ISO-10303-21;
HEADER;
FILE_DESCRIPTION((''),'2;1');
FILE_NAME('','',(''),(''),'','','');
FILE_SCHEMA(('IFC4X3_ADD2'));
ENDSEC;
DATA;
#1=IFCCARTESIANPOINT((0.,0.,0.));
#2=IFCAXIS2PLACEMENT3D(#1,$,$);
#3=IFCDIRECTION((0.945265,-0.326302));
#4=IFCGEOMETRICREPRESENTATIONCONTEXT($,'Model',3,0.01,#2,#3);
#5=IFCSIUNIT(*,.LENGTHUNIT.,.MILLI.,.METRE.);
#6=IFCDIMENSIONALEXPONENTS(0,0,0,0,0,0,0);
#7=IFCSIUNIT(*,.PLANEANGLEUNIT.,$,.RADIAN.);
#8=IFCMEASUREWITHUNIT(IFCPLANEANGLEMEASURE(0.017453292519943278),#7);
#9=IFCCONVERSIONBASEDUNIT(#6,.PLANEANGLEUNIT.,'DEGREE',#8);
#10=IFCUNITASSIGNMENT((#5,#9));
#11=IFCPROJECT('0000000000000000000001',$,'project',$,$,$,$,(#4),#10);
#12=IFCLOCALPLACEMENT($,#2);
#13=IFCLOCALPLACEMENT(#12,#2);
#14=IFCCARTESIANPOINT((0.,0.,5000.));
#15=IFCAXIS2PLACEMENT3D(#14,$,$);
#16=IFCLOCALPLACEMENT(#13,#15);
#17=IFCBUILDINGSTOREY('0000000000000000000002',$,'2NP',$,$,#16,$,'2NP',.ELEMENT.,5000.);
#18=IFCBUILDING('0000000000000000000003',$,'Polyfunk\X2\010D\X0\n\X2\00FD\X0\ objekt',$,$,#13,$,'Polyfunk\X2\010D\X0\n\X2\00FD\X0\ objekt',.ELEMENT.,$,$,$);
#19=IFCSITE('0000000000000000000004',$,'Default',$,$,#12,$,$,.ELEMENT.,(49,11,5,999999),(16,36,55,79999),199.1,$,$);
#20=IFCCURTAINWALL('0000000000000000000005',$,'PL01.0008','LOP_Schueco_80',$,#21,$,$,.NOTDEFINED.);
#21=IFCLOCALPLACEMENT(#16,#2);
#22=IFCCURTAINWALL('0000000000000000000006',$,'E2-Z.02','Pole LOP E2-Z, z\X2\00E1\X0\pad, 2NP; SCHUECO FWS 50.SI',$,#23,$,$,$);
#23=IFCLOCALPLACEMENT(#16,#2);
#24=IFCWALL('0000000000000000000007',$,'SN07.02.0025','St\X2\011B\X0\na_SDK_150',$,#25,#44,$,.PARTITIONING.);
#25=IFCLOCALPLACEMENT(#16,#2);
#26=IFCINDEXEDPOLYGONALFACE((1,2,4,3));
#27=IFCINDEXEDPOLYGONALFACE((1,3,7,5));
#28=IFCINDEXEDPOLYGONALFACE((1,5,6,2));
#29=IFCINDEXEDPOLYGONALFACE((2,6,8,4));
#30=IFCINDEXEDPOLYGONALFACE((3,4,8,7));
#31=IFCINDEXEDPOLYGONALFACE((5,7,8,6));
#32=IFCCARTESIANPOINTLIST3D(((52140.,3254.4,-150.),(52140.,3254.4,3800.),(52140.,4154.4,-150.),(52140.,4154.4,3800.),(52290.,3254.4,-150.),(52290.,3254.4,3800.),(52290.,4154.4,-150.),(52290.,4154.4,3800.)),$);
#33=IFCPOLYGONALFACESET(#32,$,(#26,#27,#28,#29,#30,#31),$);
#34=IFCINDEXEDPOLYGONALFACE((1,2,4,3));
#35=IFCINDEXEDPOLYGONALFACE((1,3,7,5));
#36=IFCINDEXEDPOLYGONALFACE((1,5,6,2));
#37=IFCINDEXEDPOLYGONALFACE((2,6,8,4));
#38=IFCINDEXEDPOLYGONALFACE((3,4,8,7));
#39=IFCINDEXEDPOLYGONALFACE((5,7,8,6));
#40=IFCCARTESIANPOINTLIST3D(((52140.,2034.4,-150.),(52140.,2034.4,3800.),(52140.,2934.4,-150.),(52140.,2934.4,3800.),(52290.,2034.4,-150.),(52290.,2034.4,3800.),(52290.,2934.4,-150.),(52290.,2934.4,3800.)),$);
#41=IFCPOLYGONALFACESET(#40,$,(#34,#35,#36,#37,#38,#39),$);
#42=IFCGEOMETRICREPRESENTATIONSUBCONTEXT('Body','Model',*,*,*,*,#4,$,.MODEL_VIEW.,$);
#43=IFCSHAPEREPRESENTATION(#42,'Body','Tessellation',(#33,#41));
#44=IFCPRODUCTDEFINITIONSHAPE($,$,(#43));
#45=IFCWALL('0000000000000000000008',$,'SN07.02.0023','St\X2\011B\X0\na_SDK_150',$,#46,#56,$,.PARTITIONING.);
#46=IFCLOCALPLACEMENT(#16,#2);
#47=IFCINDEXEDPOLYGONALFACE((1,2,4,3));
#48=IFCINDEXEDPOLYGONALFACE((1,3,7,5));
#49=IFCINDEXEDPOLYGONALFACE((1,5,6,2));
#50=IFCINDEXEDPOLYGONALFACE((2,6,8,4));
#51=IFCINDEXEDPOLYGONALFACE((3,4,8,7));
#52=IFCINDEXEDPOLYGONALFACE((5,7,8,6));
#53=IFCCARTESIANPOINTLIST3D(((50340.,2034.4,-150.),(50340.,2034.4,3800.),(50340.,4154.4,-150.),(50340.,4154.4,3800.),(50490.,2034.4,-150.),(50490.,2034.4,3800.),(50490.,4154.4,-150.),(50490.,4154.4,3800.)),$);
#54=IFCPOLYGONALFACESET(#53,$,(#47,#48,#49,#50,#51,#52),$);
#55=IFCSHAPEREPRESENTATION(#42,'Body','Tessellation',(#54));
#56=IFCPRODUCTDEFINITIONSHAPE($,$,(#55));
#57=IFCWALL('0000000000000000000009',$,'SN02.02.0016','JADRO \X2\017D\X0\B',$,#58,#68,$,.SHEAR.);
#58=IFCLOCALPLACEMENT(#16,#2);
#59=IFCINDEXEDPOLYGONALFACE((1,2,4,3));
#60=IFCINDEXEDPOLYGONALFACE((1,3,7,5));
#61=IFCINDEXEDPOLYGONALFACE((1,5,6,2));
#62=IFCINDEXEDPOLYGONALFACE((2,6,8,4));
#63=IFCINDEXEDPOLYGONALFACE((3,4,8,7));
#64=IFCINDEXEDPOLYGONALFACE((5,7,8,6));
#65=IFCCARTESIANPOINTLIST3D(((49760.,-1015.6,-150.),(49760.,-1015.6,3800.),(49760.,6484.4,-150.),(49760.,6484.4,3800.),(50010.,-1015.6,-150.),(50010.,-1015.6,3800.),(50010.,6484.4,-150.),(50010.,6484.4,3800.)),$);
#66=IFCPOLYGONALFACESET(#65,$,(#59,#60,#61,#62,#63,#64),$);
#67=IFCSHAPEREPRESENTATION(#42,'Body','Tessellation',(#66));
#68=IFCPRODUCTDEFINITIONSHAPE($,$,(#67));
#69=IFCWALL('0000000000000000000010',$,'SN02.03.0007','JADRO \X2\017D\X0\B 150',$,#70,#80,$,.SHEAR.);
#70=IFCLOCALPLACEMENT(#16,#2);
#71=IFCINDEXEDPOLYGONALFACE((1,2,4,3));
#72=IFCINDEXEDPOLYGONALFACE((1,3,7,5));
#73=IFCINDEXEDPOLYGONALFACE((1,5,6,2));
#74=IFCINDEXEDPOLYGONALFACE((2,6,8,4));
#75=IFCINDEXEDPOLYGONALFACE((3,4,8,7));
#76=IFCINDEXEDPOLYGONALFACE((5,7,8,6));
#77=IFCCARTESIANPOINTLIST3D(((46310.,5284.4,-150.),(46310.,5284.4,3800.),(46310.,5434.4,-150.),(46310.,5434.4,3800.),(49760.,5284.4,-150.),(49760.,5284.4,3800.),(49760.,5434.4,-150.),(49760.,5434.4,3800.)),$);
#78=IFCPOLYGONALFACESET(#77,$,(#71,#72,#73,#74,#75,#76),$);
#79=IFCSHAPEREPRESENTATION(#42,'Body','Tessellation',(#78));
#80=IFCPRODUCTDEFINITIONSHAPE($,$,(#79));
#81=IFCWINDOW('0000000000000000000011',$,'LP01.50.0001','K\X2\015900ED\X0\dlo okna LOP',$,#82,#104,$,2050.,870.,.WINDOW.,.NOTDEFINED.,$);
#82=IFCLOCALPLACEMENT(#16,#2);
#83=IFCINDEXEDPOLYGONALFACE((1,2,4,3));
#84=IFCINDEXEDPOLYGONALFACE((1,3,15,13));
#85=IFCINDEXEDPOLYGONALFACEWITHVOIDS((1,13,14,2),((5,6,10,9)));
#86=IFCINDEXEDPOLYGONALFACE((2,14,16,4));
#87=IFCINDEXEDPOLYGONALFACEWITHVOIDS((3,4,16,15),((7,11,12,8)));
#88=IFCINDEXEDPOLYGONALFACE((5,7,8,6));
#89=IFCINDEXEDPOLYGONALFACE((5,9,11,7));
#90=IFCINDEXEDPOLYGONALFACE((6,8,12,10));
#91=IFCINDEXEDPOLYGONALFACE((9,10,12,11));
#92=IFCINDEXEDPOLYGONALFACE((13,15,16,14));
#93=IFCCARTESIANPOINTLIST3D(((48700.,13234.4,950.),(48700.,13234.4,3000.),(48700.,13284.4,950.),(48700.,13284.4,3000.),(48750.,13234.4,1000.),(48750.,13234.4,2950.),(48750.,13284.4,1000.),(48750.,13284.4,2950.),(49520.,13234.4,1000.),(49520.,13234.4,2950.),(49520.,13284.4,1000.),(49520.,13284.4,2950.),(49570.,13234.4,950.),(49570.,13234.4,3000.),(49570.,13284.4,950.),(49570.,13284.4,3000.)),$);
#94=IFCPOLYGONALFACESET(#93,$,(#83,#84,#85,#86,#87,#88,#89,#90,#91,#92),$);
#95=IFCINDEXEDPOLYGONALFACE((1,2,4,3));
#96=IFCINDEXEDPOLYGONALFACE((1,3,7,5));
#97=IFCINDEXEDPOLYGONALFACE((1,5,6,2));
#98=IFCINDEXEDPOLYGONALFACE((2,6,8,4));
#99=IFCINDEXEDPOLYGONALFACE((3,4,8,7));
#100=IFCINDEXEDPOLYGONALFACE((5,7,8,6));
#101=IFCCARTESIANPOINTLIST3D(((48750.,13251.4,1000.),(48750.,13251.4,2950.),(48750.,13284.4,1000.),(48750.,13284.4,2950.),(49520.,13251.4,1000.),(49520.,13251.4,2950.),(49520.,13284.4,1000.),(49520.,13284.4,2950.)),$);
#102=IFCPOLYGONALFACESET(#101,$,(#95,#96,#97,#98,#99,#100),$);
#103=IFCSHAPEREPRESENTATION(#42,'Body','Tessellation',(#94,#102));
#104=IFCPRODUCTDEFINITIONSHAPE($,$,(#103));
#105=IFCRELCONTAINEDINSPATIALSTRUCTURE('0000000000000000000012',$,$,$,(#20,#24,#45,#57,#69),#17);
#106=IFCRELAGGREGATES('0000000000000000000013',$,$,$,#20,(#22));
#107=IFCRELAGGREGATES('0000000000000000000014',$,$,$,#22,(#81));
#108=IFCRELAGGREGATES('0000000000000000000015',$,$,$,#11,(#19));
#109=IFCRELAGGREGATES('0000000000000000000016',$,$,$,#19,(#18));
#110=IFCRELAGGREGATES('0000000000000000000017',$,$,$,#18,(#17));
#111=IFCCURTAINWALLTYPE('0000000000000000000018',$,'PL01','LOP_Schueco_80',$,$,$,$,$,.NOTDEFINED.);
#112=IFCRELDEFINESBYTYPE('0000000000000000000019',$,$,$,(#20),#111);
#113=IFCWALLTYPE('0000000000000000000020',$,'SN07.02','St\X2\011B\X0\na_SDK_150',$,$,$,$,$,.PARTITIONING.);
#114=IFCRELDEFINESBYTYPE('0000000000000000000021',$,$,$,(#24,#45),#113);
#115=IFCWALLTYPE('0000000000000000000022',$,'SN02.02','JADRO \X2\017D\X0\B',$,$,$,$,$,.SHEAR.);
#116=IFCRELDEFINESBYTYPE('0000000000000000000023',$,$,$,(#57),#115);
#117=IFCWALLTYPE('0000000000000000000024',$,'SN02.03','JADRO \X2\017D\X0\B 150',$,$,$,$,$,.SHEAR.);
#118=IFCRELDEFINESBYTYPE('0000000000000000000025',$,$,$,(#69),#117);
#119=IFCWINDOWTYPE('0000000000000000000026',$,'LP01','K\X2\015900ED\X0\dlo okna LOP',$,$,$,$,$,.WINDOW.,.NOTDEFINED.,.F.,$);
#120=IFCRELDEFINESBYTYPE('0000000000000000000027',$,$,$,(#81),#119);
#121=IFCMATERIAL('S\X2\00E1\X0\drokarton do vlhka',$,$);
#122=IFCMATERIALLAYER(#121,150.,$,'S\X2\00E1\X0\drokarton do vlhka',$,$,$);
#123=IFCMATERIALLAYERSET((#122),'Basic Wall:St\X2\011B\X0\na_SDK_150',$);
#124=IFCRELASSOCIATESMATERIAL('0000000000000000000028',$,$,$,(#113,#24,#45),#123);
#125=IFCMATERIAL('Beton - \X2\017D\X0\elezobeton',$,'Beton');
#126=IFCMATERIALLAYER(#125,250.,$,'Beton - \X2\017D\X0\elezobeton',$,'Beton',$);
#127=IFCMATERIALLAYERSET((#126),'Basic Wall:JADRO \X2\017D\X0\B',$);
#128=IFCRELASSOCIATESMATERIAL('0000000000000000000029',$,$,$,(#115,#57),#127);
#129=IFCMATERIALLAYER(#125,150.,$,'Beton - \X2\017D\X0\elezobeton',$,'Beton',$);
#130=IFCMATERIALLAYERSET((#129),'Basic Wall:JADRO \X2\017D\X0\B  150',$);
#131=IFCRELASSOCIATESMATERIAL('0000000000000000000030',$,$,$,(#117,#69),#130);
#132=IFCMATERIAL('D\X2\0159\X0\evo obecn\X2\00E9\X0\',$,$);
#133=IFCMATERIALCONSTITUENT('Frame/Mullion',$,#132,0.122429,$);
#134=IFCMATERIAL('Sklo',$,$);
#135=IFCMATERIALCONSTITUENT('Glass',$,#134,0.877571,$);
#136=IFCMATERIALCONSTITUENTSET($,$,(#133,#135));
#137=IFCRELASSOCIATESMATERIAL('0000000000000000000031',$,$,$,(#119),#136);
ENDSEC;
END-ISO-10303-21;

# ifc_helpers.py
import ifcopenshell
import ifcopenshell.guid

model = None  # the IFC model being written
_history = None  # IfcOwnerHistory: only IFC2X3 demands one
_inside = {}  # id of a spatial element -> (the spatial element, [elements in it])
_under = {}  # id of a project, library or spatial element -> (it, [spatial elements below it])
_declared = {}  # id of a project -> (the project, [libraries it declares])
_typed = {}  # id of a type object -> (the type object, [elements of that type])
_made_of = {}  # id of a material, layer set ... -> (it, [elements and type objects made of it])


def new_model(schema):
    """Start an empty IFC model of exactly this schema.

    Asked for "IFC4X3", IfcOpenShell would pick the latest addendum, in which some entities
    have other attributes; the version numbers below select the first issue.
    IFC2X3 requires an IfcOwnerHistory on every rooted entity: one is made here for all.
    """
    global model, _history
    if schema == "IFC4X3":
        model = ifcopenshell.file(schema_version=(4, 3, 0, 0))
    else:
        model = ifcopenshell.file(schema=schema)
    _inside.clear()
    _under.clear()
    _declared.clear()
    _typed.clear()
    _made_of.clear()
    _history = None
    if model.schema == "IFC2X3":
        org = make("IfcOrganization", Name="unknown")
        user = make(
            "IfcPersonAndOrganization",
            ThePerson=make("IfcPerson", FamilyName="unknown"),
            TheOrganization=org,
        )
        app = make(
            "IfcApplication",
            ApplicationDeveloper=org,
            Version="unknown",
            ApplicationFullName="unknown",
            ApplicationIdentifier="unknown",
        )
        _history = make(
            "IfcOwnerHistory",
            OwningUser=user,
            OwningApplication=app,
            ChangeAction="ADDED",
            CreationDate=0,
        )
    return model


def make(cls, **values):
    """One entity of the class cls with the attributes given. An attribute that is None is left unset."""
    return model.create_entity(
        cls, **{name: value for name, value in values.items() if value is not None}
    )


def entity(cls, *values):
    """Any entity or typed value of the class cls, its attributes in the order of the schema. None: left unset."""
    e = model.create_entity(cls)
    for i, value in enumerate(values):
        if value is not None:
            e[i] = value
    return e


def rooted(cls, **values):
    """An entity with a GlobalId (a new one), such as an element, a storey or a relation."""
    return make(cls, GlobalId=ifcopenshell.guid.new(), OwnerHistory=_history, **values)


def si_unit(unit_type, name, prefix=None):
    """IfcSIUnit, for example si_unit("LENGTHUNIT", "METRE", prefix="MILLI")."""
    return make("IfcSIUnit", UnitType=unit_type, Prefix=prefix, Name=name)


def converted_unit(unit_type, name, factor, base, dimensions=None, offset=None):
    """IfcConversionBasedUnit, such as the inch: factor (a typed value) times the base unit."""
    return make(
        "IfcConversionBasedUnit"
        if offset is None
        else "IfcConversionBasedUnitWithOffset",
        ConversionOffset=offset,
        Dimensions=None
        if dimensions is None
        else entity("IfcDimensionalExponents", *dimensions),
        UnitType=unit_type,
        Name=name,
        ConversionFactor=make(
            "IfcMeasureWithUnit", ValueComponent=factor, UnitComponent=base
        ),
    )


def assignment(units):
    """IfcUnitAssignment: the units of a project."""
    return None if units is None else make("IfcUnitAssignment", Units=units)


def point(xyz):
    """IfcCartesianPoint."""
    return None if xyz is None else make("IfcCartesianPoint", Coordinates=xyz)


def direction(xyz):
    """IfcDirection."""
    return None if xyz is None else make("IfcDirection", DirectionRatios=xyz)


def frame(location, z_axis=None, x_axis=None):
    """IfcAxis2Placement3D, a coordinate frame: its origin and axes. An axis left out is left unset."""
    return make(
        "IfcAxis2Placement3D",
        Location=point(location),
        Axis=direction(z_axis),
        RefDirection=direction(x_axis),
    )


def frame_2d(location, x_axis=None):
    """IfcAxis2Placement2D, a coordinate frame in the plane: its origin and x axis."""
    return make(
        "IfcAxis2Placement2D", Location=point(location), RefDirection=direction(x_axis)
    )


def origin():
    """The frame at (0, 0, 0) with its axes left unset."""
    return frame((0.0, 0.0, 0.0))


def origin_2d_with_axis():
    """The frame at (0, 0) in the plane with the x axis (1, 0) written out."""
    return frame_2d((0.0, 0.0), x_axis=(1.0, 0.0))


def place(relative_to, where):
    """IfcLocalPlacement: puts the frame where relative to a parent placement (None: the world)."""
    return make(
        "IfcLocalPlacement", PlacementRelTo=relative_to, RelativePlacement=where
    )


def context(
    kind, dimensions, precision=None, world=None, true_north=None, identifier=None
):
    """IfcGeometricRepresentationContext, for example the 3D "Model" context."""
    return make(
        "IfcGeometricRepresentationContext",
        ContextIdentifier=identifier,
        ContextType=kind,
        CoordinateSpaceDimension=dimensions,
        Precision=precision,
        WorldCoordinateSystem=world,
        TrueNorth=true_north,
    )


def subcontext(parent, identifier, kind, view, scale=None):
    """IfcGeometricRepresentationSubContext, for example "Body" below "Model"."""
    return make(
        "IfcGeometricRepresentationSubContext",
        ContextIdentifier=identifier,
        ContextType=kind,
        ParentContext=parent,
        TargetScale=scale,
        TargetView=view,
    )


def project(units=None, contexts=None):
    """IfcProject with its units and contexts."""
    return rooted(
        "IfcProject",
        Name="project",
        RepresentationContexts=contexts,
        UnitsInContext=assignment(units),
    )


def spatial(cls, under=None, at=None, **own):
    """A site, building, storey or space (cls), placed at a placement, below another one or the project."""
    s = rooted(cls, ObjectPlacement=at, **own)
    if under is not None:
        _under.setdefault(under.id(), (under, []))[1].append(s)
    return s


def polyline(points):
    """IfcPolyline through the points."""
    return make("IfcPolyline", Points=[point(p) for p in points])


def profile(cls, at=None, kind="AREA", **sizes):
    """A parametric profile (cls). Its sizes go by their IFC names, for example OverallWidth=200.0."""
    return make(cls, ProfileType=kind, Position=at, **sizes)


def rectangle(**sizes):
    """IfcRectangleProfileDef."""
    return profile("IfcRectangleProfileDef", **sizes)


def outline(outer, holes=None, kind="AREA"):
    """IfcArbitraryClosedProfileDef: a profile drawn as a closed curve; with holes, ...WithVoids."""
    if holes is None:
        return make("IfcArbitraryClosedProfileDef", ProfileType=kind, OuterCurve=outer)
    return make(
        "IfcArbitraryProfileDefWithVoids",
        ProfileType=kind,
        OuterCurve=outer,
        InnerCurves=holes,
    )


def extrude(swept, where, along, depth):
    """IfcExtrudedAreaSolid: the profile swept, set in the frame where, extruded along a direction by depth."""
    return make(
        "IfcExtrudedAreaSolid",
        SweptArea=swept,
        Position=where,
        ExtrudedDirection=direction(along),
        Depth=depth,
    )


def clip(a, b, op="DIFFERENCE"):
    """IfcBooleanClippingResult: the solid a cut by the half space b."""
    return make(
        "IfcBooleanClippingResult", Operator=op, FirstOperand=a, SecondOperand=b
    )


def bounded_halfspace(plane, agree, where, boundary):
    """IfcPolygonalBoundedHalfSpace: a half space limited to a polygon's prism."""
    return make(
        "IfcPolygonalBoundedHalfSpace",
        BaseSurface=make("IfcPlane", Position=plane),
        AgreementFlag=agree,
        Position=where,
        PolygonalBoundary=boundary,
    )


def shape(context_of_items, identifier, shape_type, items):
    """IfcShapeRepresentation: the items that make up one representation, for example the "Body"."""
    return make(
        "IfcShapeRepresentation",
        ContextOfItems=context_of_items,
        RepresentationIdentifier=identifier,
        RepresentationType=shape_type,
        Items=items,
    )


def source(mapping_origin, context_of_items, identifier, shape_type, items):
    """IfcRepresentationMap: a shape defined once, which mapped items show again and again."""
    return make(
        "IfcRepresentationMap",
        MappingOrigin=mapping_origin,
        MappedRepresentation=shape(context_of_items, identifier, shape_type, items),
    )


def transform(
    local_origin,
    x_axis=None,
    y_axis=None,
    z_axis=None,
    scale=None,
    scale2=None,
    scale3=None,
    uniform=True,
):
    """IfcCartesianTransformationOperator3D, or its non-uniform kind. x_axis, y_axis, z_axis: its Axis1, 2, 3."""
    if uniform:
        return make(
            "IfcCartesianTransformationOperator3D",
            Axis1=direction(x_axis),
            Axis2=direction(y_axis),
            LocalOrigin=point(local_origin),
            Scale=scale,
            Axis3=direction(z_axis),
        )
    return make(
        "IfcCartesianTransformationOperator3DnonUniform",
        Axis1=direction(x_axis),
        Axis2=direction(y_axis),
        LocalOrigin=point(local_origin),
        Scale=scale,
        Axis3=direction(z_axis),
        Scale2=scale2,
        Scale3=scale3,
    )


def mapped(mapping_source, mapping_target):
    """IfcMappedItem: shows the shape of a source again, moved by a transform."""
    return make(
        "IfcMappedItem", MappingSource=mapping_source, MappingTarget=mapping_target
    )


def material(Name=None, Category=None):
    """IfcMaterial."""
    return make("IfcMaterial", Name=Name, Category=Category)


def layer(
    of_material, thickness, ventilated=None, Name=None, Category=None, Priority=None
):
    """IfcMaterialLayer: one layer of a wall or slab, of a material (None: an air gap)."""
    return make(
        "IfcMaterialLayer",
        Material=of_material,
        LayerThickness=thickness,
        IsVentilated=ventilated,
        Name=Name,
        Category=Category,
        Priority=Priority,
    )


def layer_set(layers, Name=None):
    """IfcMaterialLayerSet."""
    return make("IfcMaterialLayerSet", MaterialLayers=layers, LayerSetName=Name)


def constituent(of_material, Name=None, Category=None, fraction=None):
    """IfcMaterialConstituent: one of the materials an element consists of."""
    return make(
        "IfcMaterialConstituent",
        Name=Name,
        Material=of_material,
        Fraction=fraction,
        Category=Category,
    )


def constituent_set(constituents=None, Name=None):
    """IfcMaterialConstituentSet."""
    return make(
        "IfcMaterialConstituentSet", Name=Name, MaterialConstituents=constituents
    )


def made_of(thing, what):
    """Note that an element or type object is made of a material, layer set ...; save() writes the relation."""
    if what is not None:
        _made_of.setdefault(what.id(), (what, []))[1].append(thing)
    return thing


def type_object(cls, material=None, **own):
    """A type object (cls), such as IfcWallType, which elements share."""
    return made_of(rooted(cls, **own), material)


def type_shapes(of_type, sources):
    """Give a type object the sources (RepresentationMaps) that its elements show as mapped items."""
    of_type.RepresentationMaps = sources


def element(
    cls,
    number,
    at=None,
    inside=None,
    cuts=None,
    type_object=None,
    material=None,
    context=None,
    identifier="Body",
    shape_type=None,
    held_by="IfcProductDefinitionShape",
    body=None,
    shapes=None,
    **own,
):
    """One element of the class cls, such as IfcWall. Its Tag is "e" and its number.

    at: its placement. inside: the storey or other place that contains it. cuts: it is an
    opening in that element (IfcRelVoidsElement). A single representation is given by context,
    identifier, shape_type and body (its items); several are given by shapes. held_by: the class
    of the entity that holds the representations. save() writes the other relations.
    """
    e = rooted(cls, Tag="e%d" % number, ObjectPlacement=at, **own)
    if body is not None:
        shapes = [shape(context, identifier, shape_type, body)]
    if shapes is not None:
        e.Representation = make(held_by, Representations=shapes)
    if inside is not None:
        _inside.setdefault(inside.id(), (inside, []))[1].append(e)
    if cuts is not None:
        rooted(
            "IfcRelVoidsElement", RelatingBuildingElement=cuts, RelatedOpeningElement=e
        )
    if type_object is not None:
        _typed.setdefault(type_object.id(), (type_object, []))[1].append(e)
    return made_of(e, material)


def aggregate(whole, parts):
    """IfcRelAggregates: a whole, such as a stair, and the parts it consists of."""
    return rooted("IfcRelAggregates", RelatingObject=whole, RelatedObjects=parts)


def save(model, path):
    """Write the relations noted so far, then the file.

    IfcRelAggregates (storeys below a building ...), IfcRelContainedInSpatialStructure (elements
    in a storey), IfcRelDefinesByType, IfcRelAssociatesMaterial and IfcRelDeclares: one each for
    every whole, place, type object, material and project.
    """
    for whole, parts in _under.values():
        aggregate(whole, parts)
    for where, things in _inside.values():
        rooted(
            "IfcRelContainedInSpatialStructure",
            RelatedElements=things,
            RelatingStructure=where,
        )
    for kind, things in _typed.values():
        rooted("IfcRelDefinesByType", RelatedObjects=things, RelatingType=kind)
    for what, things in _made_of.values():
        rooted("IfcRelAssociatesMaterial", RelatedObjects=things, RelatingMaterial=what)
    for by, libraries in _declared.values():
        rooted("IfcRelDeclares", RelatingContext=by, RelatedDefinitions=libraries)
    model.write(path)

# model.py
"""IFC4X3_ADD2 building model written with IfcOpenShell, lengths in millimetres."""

from ifc_helpers import new_model, entity, si_unit, converted_unit, direction, frame, frame_2d, origin, origin_2d_with_axis, place, context, subcontext, project, spatial, polyline, rectangle, outline, extrude, clip, bounded_halfspace, source, transform, mapped, material, layer, layer_set, constituent, constituent_set, type_object, type_shapes, element, aggregate, save


model = new_model("IFC4X3_ADD2")

# Units and contexts
model_context = context("Model", 3, precision=0.01, world=origin(), true_north=direction((0.945265, -0.326302)))
body_context = subcontext(model_context, "Body", "Model", "MODEL_VIEW")
ifc_project = project(units=[si_unit("LENGTHUNIT", "METRE", prefix="MILLI"), converted_unit("PLANEANGLEUNIT", "DEGREE", entity("IfcPlaneAngleMeasure", 0.017453292519943278), si_unit("PLANEANGLEUNIT", "RADIAN"), dimensions=[0, 0, 0, 0, 0, 0, 0])], contexts=[model_context])

# Site, building, storey
site_placement = place(None, origin())
site = spatial("IfcSite", under=ifc_project, at=site_placement, Name="Default", CompositionType="ELEMENT", RefLatitude=(49, 11, 5, 999999), RefLongitude=(16, 36, 55, 79999), RefElevation=199.1)
building_placement = place(site_placement, origin())
building = spatial("IfcBuilding", under=site, at=building_placement, Name="Polyfunkčný objekt", LongName="Polyfunkčný objekt", CompositionType="ELEMENT")
storey_placement = place(building_placement, frame((0.0, 0.0, 5000.0)))
storey = spatial("IfcBuildingStorey", under=building, at=storey_placement, Name="2NP", LongName="2NP", CompositionType="ELEMENT", Elevation=5000.0)

# Curtain walls
curtain_wall_type = type_object("IfcCurtainWallType", Name="PL01", Description="LOP_Schueco_80", PredefinedType="NOTDEFINED")
curtain_wall_1_placement = place(storey_placement, frame((0.0, 0.0, -5000.0)))
curtain_wall_1 = element("IfcCurtainWall", 1, at=curtain_wall_1_placement, inside=storey, type_object=curtain_wall_type, Name="PL01.0008", Description="LOP_Schueco_80", PredefinedType="NOTDEFINED")
curtain_wall_2 = element("IfcCurtainWall", 2, Name="E2-Z.02", Description="Pole LOP E2-Z, západ, 2NP; SCHUECO FWS 50.SI")
aggregate(curtain_wall_1, [curtain_wall_2])
ifc_material_1 = material(Name="Sklo")

# Walls
ifc_material_2 = material(Name="Sádrokarton do vlhka")
ifc_layer_1 = layer(ifc_material_2, 150.0, Name="Sádrokarton do vlhka")
ifc_layer_set_1 = layer_set([ifc_layer_1], Name="Basic Wall:Stěna_SDK_150")
wall_type_1 = type_object("IfcWallType", Name="SN07.02", Description="Stěna_SDK_150", PredefinedType="PARTITIONING", material=ifc_layer_set_1)
wall_1_placement = place(storey_placement, frame((52215.0, 4154.4, -150.0), z_axis=(0.0, 0.0, 1.0), x_axis=(0.0, -1.0, 0.0)))
element("IfcWall", 3, at=wall_1_placement, inside=storey, type_object=wall_type_1, material=ifc_layer_set_1, Name="SN07.02.0025", Description="Stěna_SDK_150", PredefinedType="PARTITIONING", context=body_context, shape_type="SweptSolid", body=[
    extrude(rectangle(XDim=900.0, YDim=150.0, at=frame_2d((0.0, 0.0), x_axis=(1.0, 0.0))), frame((450.0, 0.0, 0.0)), (0.0, 0.0, 1.0), 3950.0),
    extrude(rectangle(XDim=900.0, YDim=150.0, at=frame_2d((0.0, 0.0), x_axis=(1.0, 0.0))), frame((1670.0, 0.0, 0.0), z_axis=(0.0, 0.0, 1.0), x_axis=(-1.0, 0.0, 0.0)), (0.0, 0.0, 1.0), 3950.0),
])
wall_2_placement = place(storey_placement, frame((50415.0, 4154.4, -150.0), z_axis=(0.0, 0.0, 1.0), x_axis=(0.0, -1.0, 0.0)))
element("IfcWall", 4, at=wall_2_placement, inside=storey, type_object=wall_type_1, material=ifc_layer_set_1, Name="SN07.02.0023", Description="Stěna_SDK_150", PredefinedType="PARTITIONING", context=body_context, shape_type="Clipping", body=[
    clip(clip(extrude(rectangle(XDim=2120.0, YDim=150.0, at=frame_2d((1060.0, 0.0), x_axis=(-1.0, 0.0))), origin(), (0.0, 0.0, 1.0), 3950.0), bounded_halfspace(frame((2120.0, -75.0, 0.0), z_axis=(0.0, 0.0, 1.0), x_axis=(0.0, -1.0, 0.0)), True, frame((2120.0, -75.0, 0.0)), polyline([(0.0, 0.0), (0.0, 150.0), (-900.0, 150.0), (-1220.0, 150.0), (-2120.0, 150.0), (-2120.0, 0.0), (0.0, 0.0)]))), bounded_halfspace(frame((0.0, -75.0, 3950.0), z_axis=(0.0, 0.0, -1.0), x_axis=(0.0, 1.0, 0.0)), True, frame((0.0, -75.0, 3950.0)), polyline([(0.0, 0.0), (2120.0, 0.0), (2120.0, 150.0), (1220.0, 150.0), (900.0, 150.0), (0.0, 150.0), (0.0, 0.0)]))),
])
ifc_material_3 = material(Name="Beton - Železobeton", Category="Beton")
ifc_layer_2 = layer(ifc_material_3, 250.0, Name="Beton - Železobeton", Category="Beton")
ifc_layer_set_2 = layer_set([ifc_layer_2], Name="Basic Wall:JADRO ŽB")
wall_type_2 = type_object("IfcWallType", Name="SN02.02", Description="JADRO ŽB", PredefinedType="SHEAR", material=ifc_layer_set_2)
placement = place(building_placement, origin())
wall_3_placement = place(placement, frame((49885.0, 6484.4, 4850.0), z_axis=(0.0, 0.0, 1.0), x_axis=(0.0, -1.0, 0.0)))
element("IfcWall", 5, at=wall_3_placement, inside=storey, type_object=wall_type_2, material=ifc_layer_set_2, Name="SN02.02.0016", Description="JADRO ŽB", PredefinedType="SHEAR", context=body_context, shape_type="Clipping", body=[
    clip(clip(extrude(rectangle(XDim=7500.0, YDim=250.0, at=frame_2d((3750.0, 0.0), x_axis=(-1.0, 0.0))), origin(), (0.0, 0.0, 1.0), 3950.0), bounded_halfspace(frame((7500.0, -125.0, 0.0), z_axis=(0.0, 0.0, 1.0), x_axis=(0.0, -1.0, 0.0)), True, frame((7500.0, -125.0, 0.0)), polyline([(0.0, 0.0), (0.0, 250.0), (-7500.0, 250.0), (-7500.0, 0.0), (-7250.0, 0.0), (-6450.0, 0.0), (-6300.0, 0.0), (0.0, 0.0)]))), bounded_halfspace(frame((0.0, -125.0, 3950.0), z_axis=(0.0, 0.0, -1.0), x_axis=(0.0, 1.0, 0.0)), True, frame((0.0, -125.0, 3950.0)), polyline([(0.0, 0.0), (250.0, 0.0), (1050.0, 0.0), (1200.0, 0.0), (7500.0, 0.0), (7500.0, 250.0), (0.0, 250.0), (0.0, 0.0)]))),
])
ifc_layer_3 = layer(ifc_material_3, 150.0, Name="Beton - Železobeton", Category="Beton")
ifc_layer_set_3 = layer_set([ifc_layer_3], Name="Basic Wall:JADRO ŽB  150")
wall_type_3 = type_object("IfcWallType", Name="SN02.03", Description="JADRO ŽB 150", PredefinedType="SHEAR", material=ifc_layer_set_3)
wall_4_placement = place(placement, frame((46310.0, 5359.4, 4850.0)))
element("IfcWall", 6, at=wall_4_placement, inside=storey, type_object=wall_type_3, material=ifc_layer_set_3, Name="SN02.03.0007", Description="JADRO ŽB 150", PredefinedType="SHEAR", context=body_context, shape_type="SweptSolid", body=[
    extrude(rectangle(XDim=3450.0, YDim=150.0, at=frame_2d((1725.0, 0.0), x_axis=(-1.0, 0.0))), origin(), (0.0, 0.0, 1.0), 3950.0),
])

# Window
ifc_material_4 = material(Name="Dřevo obecné")
ifc_constituent_1 = constituent(ifc_material_4, Name="Frame/Mullion", fraction=0.122429)
ifc_constituent_2 = constituent(ifc_material_1, Name="Glass", fraction=0.877571)
ifc_constituent_set = constituent_set(constituents=[ifc_constituent_1, ifc_constituent_2])
window_type = type_object("IfcWindowType", Name="LP01", Description="Křídlo okna LOP", ParameterTakesPrecedence=False, PartitioningType="NOTDEFINED", PredefinedType="WINDOW", material=ifc_constituent_set)
shared_shape_1 = source(origin(), body_context, "Body", "SweptSolid", [
    extrude(outline(polyline([(-1025.0, -435.0), (1025.0, -435.0), (1025.0, 435.0), (-1025.0, 435.0), (-1025.0, -435.0)]), holes=[polyline([(-975.0, -385.0), (-975.0, 385.0), (975.0, 385.0), (975.0, -385.0), (-975.0, -385.0)])]), frame((0.0, 0.0, 1025.0), z_axis=(0.0, 1.0, 0.0), x_axis=(0.0, 0.0, -1.0)), (0.0, 0.0, 1.0), 50.0),
    extrude(rectangle(XDim=33.0, YDim=770.0, at=origin_2d_with_axis()), frame((0.0, 33.5, 50.0), z_axis=(0.0, 0.0, 1.0), x_axis=(0.0, -1.0, 0.0)), (0.0, 0.0, 1.0), 1950.0),
])
type_shapes(window_type, [shared_shape_1])
window_placement = place(curtain_wall_1_placement, frame((49135.0, 13234.4, 5950.0)))
window = element("IfcWindow", 7, at=window_placement, type_object=window_type, Name="LP01.50.0001", Description="Křídlo okna LOP", OverallHeight=2050.0, OverallWidth=870.0, PartitioningType="NOTDEFINED", PredefinedType="WINDOW", context=body_context, shape_type="MappedRepresentation", body=[
    mapped(shared_shape_1, transform((0.0, 0.0, 0.0), scale=1.0)),
])
aggregate(curtain_wall_2, [window])

save(model, "model.ifc")
